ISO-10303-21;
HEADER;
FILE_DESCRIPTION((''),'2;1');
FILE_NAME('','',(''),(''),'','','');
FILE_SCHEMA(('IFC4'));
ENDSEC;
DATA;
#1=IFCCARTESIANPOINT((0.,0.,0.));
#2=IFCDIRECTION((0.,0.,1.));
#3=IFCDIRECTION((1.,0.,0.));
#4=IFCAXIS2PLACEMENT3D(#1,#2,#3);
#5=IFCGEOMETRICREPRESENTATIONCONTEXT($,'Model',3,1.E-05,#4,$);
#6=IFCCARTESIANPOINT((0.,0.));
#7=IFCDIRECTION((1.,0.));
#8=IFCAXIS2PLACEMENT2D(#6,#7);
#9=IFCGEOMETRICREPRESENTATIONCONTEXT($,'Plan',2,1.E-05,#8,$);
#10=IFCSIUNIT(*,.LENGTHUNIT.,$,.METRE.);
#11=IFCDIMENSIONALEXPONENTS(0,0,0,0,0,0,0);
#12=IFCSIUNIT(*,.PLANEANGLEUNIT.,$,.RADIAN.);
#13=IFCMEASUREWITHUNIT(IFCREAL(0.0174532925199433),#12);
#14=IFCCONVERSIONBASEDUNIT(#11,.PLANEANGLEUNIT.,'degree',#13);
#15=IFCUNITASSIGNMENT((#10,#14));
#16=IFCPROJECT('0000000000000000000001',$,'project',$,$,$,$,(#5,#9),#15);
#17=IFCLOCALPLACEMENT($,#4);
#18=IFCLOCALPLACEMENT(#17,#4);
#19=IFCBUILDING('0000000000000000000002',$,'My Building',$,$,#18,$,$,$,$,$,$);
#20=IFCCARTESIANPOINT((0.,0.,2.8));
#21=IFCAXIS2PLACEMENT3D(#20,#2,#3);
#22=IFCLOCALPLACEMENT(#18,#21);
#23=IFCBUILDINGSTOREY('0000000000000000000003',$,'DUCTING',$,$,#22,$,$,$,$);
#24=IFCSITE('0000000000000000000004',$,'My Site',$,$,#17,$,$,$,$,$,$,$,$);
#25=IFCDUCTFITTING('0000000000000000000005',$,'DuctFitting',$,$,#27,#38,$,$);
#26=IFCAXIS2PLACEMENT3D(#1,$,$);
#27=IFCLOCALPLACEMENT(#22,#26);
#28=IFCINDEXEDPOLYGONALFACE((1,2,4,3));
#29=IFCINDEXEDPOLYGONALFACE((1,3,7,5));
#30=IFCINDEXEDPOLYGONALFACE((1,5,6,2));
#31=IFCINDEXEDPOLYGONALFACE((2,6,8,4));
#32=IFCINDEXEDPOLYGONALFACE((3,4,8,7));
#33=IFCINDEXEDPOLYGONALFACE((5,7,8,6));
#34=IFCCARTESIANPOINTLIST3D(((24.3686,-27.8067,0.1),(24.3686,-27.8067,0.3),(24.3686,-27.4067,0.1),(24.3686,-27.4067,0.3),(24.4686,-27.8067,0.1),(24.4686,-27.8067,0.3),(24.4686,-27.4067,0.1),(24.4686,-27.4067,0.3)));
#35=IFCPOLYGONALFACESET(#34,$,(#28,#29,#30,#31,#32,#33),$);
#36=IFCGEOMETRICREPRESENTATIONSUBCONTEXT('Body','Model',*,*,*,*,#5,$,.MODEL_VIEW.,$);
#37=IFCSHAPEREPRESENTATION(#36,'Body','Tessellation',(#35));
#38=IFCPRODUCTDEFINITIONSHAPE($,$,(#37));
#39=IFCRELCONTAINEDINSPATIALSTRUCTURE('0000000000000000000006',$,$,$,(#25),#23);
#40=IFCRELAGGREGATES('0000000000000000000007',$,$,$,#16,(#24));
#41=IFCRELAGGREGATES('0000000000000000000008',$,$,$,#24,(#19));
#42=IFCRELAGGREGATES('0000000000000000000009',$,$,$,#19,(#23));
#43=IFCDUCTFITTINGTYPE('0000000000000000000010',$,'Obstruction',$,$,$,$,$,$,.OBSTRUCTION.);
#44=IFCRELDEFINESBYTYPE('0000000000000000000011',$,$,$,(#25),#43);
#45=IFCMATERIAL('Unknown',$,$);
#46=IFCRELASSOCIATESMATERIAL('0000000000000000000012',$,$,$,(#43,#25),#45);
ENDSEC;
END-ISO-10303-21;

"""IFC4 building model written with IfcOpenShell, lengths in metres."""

from ifc_helpers import new_model, entity, si_unit, converted_unit, frame, origin_with_axes, origin_2d_with_axis, place, context, subcontext, project, spatial, rectangle, extrude, material, material_profile, profile_set, profile_usage, type_object, element, save


model = new_model("IFC4")

# Units and contexts
model_context = context("Model", 3, precision=1e-05, world=origin_with_axes())
plan_context = context("Plan", 2, precision=1e-05, world=origin_2d_with_axis())
body_context = subcontext(model_context, "Body", "Model", "MODEL_VIEW")
ifc_project = project(units=[si_unit("LENGTHUNIT", "METRE"), converted_unit("PLANEANGLEUNIT", "degree", entity("IfcReal", 0.0174532925199433), si_unit("PLANEANGLEUNIT", "RADIAN"), dimensions=[0, 0, 0, 0, 0, 0, 0])], contexts=[model_context, plan_context])

# Site, building, storey
site_placement = place(None, origin_with_axes())
site = spatial("IfcSite", under=ifc_project, at=site_placement, Name="My Site")
building_placement = place(site_placement, origin_with_axes())
building = spatial("IfcBuilding", under=site, at=building_placement, Name="My Building")
storey_placement = place(building_placement, frame((0.0, 0.0, 2.8), z_axis=(0.0, 0.0, 1.0), x_axis=(1.0, 0.0, 0.0)))
storey = spatial("IfcBuildingStorey", under=building, at=storey_placement, Name="DUCTING")

# Shared definitions
ifc_material = material(Name="Unknown")

# Duct fitting
ifc_material_profile_1 = material_profile(ifc_material, rectangle(XDim=0.4, YDim=0.2))
ifc_profile_set_1 = profile_set([ifc_material_profile_1])
duct_fitting_type_1 = type_object("IfcDuctFittingType", Name="Obstruction", PredefinedType="OBSTRUCTION", material=ifc_profile_set_1)
ifc_profile_usage_1 = profile_usage(ifc_profile_set_1, cardinal=5)
duct_fitting_1_placement = place(storey_placement, frame((24.3686, -27.6067, 0.2), z_axis=(1.0, 0.0, 0.0), x_axis=(0.0, 1.0, 0.0)))
element("IfcDuctFitting", 1, at=duct_fitting_1_placement, inside=storey, type_object=duct_fitting_type_1, material=ifc_profile_usage_1, Name="DuctFitting", context=body_context, shape_type="SweptSolid", body=[
    extrude(rectangle(XDim=0.4, YDim=0.2), origin_with_axes(), (0.0, 0.0, 1.0), 0.1),
])

save(model, "model.ifc")
